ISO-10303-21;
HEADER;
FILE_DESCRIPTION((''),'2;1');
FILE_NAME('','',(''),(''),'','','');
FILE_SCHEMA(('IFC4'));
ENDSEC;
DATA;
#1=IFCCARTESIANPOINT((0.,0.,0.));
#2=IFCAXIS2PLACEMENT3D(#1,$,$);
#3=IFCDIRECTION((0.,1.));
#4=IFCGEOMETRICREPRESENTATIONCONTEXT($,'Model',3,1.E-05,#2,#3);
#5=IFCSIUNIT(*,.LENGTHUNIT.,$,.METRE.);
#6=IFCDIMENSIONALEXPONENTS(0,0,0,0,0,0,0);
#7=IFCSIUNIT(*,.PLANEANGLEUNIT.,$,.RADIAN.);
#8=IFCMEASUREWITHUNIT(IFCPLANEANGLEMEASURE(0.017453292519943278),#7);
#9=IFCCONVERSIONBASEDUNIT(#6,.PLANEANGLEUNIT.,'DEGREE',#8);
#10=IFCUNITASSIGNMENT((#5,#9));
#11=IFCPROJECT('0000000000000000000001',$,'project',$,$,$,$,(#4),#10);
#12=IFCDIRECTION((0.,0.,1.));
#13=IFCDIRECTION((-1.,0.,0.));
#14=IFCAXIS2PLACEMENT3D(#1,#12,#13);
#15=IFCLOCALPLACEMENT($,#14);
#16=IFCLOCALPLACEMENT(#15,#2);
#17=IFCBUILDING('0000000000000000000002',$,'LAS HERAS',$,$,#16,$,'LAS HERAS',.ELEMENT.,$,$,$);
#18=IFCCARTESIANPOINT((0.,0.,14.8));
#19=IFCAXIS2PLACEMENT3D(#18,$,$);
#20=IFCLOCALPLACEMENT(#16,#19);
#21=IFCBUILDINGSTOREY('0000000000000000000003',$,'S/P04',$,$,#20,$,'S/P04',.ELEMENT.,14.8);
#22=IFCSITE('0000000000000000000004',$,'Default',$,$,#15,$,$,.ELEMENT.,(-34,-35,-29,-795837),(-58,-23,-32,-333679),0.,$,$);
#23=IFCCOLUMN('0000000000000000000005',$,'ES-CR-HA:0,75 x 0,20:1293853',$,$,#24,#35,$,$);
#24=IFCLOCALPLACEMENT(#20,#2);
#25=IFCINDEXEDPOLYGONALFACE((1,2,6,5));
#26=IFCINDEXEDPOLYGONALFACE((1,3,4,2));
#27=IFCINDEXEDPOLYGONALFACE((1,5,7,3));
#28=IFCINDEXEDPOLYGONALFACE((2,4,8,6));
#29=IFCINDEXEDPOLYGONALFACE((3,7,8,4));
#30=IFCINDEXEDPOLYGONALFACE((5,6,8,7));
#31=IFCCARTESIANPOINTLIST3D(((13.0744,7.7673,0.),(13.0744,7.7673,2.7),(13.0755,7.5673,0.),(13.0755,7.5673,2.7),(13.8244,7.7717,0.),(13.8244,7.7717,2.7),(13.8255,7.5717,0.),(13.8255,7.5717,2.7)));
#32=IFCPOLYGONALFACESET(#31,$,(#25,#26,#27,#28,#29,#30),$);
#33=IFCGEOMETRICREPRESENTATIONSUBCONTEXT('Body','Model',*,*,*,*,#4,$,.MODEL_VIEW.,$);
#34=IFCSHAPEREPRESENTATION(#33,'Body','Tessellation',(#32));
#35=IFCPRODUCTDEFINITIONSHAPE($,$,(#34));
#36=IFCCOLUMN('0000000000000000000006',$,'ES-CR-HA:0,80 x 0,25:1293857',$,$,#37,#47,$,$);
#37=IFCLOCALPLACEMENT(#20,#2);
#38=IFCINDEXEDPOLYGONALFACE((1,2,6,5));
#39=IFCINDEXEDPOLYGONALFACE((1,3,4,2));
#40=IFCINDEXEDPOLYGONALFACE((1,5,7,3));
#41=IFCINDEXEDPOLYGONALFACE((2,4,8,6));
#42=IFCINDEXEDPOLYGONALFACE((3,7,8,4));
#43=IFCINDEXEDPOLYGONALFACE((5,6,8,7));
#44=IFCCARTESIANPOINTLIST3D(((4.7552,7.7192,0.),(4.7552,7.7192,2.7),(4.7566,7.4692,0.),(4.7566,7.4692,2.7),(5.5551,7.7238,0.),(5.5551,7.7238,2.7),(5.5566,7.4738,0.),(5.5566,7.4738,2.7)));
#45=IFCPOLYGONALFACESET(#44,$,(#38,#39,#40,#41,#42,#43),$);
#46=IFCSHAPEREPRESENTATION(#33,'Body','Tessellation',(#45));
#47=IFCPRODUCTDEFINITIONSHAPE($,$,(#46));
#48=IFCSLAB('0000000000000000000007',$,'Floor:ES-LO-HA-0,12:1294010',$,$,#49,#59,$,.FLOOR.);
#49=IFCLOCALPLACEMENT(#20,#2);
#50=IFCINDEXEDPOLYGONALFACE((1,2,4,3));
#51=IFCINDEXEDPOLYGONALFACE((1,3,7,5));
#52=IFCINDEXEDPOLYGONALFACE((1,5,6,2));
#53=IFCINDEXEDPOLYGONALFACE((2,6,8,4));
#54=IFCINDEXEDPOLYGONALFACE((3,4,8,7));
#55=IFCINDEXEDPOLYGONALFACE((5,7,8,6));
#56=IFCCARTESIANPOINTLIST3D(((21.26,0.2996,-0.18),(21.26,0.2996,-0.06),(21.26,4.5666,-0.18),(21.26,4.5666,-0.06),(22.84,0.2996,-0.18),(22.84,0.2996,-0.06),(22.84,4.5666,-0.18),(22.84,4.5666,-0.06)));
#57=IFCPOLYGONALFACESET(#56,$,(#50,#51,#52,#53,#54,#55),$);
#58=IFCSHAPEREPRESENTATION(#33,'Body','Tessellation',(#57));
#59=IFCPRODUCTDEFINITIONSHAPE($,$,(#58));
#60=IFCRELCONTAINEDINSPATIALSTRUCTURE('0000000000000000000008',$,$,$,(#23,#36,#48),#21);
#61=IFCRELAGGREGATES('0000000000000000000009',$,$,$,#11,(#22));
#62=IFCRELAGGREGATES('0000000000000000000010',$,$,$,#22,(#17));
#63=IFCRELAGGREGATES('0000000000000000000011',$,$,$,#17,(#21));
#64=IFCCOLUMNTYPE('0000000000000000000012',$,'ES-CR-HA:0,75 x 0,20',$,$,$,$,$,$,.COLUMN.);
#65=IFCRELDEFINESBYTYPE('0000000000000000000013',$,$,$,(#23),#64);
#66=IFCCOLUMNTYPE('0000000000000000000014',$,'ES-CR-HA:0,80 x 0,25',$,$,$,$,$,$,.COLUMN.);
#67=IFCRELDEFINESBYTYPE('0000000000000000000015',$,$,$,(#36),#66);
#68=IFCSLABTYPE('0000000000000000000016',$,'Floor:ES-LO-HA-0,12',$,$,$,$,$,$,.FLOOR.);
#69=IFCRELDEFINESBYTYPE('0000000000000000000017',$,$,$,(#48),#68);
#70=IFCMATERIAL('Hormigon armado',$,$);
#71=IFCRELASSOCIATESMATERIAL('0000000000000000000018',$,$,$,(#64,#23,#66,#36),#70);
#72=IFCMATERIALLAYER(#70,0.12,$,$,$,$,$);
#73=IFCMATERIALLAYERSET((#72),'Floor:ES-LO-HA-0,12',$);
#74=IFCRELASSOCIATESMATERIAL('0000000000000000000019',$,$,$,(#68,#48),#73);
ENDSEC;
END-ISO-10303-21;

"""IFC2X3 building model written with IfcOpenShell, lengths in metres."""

from ifc_helpers import new_model, entity, si_unit, converted_unit, direction, frame, frame_2d, origin, place, context, subcontext, project, spatial, rectangle, extrude, source, transform, mapped, material, layer, layer_set, layer_usage, type_object, type_shapes, element, save


model = new_model("IFC2X3")

# Units and contexts
model_context = context("Model", 3, precision=1e-05, world=origin(), true_north=direction((0.0, 1.0)))
body_context = subcontext(model_context, "Body", "Model", "MODEL_VIEW")
ifc_project = project(units=[si_unit("LENGTHUNIT", "METRE"), converted_unit("PLANEANGLEUNIT", "DEGREE", entity("IfcPlaneAngleMeasure", 0.017453292519943278), si_unit("PLANEANGLEUNIT", "RADIAN"), dimensions=[0, 0, 0, 0, 0, 0, 0])], contexts=[model_context])

# Site, building, storey
site_placement = place(None, frame((0.0, 0.0, 0.0), z_axis=(0.0, 0.0, 1.0), x_axis=(-1.0, 0.0, 0.0)))
site = spatial("IfcSite", under=ifc_project, at=site_placement, Name="Default", CompositionType="ELEMENT", RefLatitude=(-34, -35, -29, -795837), RefLongitude=(-58, -23, -32, -333679), RefElevation=0.0)
building_placement = place(site_placement, origin())
building = spatial("IfcBuilding", under=site, at=building_placement, Name="LAS HERAS", LongName="LAS HERAS", CompositionType="ELEMENT")
storey_placement = place(building_placement, frame((0.0, 0.0, 14.8)))
storey = spatial("IfcBuildingStorey", under=building, at=storey_placement, Name="S/P04", LongName="S/P04", CompositionType="ELEMENT", Elevation=14.8)

# Columns
ifc_material = material(Name="Hormigon armado")
column_type_1 = type_object("IfcColumnType", Name="ES-CR-HA:0,75 x 0,20", PredefinedType="COLUMN", material=ifc_material)
shared_shape_1 = source(origin(), body_context, "Body", "SweptSolid", [
    extrude(rectangle(XDim=0.75, YDim=0.2, at=frame_2d((0.0, 0.0), x_axis=(1.0, 0.0))), frame((13.4499, 7.6695, 14.8), z_axis=(0.0, 0.0, 1.0), x_axis=(-0.999983, -0.005788, 0.0)), (0.0, 0.0, 1.0), 2.7),
])
type_shapes(column_type_1, [shared_shape_1])
column_1_placement = place(storey_placement, frame((0.0, 0.0, -14.8)))
element("IfcColumn", 1, at=column_1_placement, inside=storey, type_object=column_type_1, material=ifc_material, Name="ES-CR-HA:0,75 x 0,20:1293853", context=body_context, shape_type="MappedRepresentation", body=[
    mapped(shared_shape_1, transform((0.0, 0.0, 0.0), scale=1.0)),
])
column_type_2 = type_object("IfcColumnType", Name="ES-CR-HA:0,80 x 0,25", PredefinedType="COLUMN", material=ifc_material)
shared_shape_2 = source(origin(), body_context, "Body", "SweptSolid", [
    extrude(rectangle(XDim=0.8, YDim=0.25, at=frame_2d((0.0, 0.0), x_axis=(1.0, 0.0))), frame((5.1559, 7.5965, 14.8), z_axis=(0.0, 0.0, 1.0), x_axis=(-0.999983, -0.005788, 0.0)), (0.0, 0.0, 1.0), 2.7),
])
type_shapes(column_type_2, [shared_shape_2])
column_2_placement = place(storey_placement, frame((0.0, 0.0, -14.8)))
element("IfcColumn", 2, at=column_2_placement, inside=storey, type_object=column_type_2, material=ifc_material, Name="ES-CR-HA:0,80 x 0,25:1293857", context=body_context, shape_type="MappedRepresentation", body=[
    mapped(shared_shape_2, transform((0.0, 0.0, 0.0), scale=1.0)),
])

# Slab
ifc_layer_1 = layer(ifc_material, 0.12)
ifc_layer_set_1 = layer_set([ifc_layer_1], Name="Floor:ES-LO-HA-0,12")
ifc_layer_usage_1 = layer_usage(ifc_layer_set_1, "AXIS3", "POSITIVE", 0.0)
slab_type_1 = type_object("IfcSlabType", Name="Floor:ES-LO-HA-0,12", PredefinedType="FLOOR", material=ifc_layer_set_1)
slab_1_placement = place(storey_placement, origin())
element("IfcSlab", 3, at=slab_1_placement, inside=storey, type_object=slab_type_1, material=ifc_layer_usage_1, Name="Floor:ES-LO-HA-0,12:1294010", PredefinedType="FLOOR", context=body_context, shape_type="SweptSolid", body=[
    extrude(rectangle(XDim=4.2671, YDim=1.58, at=frame_2d((0.0, 0.0), x_axis=(1.0, 0.0))), frame((22.05, 2.4331, -0.06), z_axis=(0.0, 0.0, -1.0), x_axis=(0.0, 1.0, 0.0)), (0.0, 0.0, 1.0), 0.12),
])

save(model, "model.ifc")
